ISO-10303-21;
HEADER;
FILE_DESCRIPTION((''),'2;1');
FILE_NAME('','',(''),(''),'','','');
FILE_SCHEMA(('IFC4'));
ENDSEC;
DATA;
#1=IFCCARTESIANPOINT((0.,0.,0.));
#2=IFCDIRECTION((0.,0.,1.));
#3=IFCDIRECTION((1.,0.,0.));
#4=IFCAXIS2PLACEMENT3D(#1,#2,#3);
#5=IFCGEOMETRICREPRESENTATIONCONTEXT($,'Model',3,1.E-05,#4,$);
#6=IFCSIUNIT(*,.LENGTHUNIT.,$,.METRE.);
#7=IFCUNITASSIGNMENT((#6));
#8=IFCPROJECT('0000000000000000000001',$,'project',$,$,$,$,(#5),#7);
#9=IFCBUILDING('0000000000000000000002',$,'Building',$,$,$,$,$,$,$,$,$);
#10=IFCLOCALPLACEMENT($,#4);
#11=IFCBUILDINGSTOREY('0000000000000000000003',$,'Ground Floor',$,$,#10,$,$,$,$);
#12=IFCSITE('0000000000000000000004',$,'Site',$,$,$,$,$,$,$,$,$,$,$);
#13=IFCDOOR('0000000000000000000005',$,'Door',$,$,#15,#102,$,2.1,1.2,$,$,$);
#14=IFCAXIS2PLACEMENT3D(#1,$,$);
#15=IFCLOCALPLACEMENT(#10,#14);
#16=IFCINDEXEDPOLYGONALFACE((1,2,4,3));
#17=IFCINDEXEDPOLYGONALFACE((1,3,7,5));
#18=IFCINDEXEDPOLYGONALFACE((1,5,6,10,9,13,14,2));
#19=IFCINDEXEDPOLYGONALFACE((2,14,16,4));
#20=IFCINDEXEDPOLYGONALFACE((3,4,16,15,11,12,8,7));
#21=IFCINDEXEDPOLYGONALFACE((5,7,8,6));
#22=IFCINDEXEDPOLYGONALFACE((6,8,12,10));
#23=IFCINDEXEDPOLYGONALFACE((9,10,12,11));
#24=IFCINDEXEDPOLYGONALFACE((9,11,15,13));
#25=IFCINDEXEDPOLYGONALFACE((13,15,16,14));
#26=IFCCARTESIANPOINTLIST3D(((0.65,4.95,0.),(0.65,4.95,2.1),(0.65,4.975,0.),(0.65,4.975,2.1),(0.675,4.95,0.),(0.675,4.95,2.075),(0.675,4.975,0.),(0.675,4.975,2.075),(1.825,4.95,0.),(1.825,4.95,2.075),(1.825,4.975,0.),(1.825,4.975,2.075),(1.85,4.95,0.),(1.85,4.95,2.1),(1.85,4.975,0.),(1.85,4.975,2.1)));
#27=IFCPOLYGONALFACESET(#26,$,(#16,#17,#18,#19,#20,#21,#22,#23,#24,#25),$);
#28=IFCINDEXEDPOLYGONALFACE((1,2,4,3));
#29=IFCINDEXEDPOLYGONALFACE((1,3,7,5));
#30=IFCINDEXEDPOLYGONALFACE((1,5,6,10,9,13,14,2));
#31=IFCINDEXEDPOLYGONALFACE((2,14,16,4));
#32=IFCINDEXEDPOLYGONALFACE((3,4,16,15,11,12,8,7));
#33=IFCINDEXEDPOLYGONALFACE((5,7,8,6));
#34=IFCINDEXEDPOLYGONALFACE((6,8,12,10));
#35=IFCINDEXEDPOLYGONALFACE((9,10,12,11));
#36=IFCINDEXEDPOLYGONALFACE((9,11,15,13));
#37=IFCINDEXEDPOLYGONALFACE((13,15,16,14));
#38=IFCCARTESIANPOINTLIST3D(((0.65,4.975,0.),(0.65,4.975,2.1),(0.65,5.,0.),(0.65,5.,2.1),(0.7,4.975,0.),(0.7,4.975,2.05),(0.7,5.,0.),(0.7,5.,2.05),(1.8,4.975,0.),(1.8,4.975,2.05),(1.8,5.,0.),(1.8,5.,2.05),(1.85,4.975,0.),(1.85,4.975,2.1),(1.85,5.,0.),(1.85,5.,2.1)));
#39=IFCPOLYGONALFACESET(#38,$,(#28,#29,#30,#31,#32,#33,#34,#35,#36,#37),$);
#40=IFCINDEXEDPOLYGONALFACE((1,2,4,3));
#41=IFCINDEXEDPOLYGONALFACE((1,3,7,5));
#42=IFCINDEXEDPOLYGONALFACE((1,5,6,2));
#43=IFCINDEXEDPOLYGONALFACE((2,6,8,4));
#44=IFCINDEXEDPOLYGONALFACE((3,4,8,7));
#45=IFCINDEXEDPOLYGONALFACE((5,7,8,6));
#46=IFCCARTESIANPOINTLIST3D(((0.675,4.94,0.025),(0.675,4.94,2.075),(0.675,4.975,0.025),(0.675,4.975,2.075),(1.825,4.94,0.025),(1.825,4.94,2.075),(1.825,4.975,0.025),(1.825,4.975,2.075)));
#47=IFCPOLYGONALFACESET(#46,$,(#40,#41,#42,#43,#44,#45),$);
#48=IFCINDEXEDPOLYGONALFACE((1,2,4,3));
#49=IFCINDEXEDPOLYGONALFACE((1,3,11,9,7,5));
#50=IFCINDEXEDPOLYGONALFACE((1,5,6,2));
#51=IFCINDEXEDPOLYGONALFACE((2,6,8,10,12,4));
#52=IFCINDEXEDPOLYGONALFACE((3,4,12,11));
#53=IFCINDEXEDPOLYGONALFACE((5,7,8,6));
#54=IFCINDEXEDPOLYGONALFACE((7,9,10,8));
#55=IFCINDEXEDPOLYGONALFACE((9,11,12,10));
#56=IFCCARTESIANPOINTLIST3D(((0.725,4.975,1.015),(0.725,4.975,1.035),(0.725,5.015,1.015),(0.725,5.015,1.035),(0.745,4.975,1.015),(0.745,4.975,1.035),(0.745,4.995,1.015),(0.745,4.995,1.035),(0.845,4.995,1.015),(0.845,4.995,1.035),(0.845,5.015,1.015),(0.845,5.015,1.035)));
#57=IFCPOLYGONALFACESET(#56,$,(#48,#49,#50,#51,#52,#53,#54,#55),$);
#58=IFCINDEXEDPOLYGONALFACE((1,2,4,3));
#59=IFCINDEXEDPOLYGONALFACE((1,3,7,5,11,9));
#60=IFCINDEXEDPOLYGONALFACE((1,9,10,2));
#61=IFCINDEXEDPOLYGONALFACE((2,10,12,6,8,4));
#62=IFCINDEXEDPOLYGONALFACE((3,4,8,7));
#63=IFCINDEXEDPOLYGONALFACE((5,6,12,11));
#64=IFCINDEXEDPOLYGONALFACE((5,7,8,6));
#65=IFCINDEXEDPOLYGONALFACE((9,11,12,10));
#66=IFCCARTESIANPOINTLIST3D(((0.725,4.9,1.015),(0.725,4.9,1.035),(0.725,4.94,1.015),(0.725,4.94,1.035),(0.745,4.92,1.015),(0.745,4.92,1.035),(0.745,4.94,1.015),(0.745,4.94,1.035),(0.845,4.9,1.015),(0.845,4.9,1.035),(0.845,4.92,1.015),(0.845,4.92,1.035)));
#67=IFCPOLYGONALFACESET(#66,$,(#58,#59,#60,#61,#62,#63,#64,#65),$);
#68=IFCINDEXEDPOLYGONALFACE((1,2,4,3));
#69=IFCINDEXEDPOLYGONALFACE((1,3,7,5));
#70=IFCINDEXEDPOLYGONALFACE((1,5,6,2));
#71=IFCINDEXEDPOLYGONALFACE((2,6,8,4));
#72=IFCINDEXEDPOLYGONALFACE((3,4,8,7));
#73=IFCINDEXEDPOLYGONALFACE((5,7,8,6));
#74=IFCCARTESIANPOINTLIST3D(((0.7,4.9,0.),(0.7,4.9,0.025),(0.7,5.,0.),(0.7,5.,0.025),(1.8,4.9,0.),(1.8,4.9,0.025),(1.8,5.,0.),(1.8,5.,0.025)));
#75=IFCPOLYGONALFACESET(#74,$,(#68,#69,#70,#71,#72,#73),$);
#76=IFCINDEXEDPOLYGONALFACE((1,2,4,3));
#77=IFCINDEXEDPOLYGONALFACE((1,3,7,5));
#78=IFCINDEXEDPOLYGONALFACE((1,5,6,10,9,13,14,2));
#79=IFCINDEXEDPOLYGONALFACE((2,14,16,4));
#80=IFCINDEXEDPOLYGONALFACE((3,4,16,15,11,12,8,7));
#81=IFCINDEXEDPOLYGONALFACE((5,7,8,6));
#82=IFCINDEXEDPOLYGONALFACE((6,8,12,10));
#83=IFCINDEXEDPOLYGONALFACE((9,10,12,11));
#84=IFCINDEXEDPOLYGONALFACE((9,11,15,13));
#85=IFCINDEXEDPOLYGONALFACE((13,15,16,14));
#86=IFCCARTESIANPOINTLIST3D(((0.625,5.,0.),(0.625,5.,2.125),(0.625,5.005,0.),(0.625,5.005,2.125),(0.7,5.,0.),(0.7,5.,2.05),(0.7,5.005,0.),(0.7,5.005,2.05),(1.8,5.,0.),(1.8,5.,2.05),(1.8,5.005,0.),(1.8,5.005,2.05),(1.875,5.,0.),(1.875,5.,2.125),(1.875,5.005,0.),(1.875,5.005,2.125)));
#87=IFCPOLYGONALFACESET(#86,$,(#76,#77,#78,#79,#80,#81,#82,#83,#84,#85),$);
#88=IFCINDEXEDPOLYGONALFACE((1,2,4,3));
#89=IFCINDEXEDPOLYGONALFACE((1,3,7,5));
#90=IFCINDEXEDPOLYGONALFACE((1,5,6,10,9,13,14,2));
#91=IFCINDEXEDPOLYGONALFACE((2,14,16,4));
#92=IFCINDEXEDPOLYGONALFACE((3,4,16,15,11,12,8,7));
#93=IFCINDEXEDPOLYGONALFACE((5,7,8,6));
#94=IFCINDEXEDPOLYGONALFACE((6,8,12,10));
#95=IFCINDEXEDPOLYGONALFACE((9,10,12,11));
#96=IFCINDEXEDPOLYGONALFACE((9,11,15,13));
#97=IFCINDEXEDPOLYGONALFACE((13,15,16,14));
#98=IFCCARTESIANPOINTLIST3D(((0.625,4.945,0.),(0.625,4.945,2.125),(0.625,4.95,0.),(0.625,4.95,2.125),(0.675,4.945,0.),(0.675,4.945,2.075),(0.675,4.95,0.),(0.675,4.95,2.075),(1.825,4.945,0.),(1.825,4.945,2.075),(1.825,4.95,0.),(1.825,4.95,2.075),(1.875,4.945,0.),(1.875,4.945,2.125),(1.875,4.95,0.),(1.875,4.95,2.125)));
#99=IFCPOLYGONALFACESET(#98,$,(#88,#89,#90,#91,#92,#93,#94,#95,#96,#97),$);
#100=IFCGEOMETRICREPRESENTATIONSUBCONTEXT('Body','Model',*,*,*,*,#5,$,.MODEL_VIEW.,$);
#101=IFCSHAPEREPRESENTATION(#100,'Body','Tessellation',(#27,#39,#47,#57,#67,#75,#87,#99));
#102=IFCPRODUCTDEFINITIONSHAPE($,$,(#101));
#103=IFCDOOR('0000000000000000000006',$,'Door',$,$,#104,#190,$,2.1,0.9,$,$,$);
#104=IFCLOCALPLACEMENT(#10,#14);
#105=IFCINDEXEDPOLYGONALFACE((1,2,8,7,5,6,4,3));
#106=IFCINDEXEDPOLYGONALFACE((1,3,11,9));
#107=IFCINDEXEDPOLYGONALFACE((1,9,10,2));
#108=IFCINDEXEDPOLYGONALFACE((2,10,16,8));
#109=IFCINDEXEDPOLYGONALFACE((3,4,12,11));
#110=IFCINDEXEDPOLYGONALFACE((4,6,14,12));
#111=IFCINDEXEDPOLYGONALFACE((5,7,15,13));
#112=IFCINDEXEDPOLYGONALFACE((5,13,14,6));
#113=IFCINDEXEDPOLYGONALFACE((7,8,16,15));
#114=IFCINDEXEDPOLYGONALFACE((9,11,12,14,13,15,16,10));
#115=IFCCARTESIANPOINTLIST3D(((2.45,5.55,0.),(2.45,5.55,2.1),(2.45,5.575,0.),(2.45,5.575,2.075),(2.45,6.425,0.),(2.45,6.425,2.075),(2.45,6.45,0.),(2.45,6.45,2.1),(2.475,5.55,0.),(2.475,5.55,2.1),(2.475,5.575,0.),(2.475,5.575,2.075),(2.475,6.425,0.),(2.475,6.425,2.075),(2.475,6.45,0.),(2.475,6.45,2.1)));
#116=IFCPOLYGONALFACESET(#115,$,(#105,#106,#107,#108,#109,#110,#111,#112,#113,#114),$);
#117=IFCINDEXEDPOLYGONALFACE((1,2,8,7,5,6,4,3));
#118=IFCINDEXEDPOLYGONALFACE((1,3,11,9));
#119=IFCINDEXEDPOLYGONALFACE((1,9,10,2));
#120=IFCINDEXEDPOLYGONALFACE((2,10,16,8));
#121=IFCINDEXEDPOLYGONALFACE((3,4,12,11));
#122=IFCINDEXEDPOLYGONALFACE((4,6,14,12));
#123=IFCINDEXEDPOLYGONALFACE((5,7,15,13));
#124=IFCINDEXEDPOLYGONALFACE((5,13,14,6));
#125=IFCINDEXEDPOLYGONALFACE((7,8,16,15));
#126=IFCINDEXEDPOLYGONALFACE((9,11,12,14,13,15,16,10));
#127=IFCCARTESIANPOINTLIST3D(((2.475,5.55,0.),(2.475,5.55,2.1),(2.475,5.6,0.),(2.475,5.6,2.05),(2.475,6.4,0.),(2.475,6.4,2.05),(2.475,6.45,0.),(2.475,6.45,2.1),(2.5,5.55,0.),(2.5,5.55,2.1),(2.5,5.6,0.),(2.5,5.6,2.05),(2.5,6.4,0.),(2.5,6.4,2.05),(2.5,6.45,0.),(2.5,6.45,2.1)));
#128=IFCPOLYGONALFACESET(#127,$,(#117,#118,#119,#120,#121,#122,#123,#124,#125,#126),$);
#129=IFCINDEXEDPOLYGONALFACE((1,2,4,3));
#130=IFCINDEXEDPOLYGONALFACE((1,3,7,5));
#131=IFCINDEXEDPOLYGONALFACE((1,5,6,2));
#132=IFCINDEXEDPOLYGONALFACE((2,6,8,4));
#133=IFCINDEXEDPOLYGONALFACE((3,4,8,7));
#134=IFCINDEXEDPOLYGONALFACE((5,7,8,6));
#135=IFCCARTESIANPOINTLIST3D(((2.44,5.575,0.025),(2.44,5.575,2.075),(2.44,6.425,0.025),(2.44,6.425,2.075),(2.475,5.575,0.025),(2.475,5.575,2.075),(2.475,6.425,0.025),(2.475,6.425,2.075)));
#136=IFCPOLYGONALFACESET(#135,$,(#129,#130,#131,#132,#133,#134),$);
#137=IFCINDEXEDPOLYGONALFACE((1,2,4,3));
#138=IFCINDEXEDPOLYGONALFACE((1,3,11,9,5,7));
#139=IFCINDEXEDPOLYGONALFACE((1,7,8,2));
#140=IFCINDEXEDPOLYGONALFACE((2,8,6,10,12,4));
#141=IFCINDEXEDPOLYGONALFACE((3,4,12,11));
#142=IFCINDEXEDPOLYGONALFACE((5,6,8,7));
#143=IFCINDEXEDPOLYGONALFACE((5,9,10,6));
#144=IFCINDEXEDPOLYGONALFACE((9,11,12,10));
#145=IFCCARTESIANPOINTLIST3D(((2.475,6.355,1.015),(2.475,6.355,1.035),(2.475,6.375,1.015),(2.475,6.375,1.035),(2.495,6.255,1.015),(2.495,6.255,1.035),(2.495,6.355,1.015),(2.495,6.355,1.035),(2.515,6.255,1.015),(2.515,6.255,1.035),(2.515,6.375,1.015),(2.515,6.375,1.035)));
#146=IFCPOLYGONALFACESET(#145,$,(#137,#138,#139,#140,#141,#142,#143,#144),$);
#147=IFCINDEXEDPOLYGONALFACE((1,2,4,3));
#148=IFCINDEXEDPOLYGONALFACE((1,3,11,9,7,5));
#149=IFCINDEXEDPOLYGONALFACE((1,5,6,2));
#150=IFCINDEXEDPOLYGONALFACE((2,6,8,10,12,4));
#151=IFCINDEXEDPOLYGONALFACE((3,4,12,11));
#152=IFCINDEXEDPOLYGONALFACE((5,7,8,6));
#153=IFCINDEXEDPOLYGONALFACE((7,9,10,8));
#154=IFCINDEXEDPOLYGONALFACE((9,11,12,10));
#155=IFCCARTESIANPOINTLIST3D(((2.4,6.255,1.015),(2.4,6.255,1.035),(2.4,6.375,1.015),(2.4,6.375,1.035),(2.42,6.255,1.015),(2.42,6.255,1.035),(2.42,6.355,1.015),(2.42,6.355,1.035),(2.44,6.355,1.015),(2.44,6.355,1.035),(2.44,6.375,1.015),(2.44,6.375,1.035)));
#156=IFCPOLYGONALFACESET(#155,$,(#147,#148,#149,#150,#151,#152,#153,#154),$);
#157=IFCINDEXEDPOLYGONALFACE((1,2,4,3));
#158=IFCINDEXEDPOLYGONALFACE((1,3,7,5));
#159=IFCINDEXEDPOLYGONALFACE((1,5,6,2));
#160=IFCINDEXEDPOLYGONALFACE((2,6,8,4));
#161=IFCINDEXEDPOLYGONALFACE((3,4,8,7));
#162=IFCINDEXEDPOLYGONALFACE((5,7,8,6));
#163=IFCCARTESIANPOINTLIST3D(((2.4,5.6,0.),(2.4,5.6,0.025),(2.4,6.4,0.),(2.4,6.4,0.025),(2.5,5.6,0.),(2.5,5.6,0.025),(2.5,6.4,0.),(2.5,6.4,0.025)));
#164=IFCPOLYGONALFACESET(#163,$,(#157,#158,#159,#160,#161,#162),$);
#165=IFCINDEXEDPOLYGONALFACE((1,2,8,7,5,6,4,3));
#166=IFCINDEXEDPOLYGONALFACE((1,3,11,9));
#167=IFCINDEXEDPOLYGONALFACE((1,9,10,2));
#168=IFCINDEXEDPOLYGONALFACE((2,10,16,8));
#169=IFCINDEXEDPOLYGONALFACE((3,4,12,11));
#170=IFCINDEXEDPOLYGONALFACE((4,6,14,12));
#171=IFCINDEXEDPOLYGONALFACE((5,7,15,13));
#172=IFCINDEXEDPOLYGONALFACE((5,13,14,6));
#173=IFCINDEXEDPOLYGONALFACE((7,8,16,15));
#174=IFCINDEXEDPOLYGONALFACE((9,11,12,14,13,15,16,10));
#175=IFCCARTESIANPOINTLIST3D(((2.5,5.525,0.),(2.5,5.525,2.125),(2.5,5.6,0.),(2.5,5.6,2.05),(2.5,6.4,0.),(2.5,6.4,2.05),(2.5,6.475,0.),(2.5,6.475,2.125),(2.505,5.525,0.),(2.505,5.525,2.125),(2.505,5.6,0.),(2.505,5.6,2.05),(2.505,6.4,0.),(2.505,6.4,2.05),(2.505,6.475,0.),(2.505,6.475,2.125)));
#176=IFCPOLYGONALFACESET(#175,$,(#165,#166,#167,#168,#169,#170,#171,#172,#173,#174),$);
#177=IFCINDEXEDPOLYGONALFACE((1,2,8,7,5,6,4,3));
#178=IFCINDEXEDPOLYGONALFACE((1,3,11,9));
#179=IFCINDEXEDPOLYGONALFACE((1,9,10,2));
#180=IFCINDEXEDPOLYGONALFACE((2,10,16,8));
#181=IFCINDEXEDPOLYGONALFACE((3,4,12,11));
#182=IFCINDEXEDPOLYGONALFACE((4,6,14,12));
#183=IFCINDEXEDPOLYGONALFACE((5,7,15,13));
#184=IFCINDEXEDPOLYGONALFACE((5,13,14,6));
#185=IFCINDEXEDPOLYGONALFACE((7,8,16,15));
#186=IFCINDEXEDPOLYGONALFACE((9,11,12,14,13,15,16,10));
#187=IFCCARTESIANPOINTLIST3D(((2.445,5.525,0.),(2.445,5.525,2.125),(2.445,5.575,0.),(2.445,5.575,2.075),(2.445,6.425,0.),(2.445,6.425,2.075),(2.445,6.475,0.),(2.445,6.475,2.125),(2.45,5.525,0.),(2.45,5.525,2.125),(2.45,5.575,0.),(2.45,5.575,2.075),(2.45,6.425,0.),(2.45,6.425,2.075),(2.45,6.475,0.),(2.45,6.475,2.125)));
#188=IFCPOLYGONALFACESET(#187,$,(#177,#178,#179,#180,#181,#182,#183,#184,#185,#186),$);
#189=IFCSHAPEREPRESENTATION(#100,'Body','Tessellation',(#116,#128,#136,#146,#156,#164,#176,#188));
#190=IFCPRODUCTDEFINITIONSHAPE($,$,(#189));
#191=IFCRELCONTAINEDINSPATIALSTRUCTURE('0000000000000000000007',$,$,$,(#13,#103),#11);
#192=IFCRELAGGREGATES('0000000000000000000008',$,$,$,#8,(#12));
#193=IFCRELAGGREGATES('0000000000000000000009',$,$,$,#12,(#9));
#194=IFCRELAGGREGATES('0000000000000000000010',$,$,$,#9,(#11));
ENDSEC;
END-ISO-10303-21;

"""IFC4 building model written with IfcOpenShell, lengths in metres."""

from ifc_helpers import new_model, si_unit, frame, origin_with_axes, place, context, subcontext, project, spatial, line, indexed_curve, outline, extrude, element, save


model = new_model("IFC4")

# Units and contexts
model_context = context("Model", 3, precision=1e-05, world=origin_with_axes())
body_context = subcontext(model_context, "Body", "Model", "MODEL_VIEW")
ifc_project = project(units=[si_unit("LENGTHUNIT", "METRE")], contexts=[model_context])

# Site, building, storey
site = spatial("IfcSite", under=ifc_project, Name="Site")
building = spatial("IfcBuilding", under=site, Name="Building")
storey_placement = place(None, origin_with_axes())
storey = spatial("IfcBuildingStorey", under=building, at=storey_placement, Name="Ground Floor")

# Doors
door_1_placement = place(storey_placement, frame((1.85, 5.0, 0.0), z_axis=(0.0, 0.0, 1.0), x_axis=(-1.0, 0.0, 0.0)))
element("IfcDoor", 1, at=door_1_placement, inside=storey, Name="Door", OverallHeight=2.1, OverallWidth=1.2, context=body_context, shape_type="SweptSolid", body=[
    extrude(outline(indexed_curve([(0.0, 0.0), (0.0, 2.1), (1.2, 2.1), (1.2, 0.0), (1.175, 0.0), (1.175, 2.075), (0.025, 2.075), (0.025, 0.0)], segments=[line(1, 2, 3, 4, 5, 6, 7, 8, 1)])), frame((0.0, 0.025, 0.0), z_axis=(0.0, -1.0, 0.0), x_axis=(1.0, 0.0, 0.0)), (0.0, 0.0, -1.0), 0.025),
    extrude(outline(indexed_curve([(0.0, 0.0), (0.0, 2.1), (1.2, 2.1), (1.2, 0.0), (1.15, 0.0), (1.15, 2.05), (0.05, 2.05), (0.05, 0.0)], segments=[line(1, 2, 3, 4, 5, 6, 7, 8, 1)])), frame((0.0, 0.0, 0.0), z_axis=(0.0, -1.0, 0.0), x_axis=(1.0, 0.0, 0.0)), (0.0, 0.0, -1.0), 0.025),
    extrude(outline(indexed_curve([(0.0, 0.0), (1.15, 0.0), (1.15, 0.035), (0.0, 0.035)], segments=[line(1, 2, 3, 4, 1)])), frame((0.025, 0.025, 0.025), z_axis=(0.0, 0.0, 1.0), x_axis=(1.0, 0.0, 0.0)), (0.0, 0.0, 1.0), 2.05),
    extrude(outline(indexed_curve([(0.0, 0.0), (0.0, -0.04), (-0.12, -0.04), (-0.12, -0.02), (-0.02, -0.02), (-0.02, 0.0)], segments=[line(1, 2, 3, 4, 5, 6, 1)])), frame((1.125, 0.025, 1.015), z_axis=(0.0, 0.0, 1.0), x_axis=(1.0, 0.0, 0.0)), (0.0, 0.0, 1.0), 0.02),
    extrude(outline(indexed_curve([(0.0, 0.0), (0.0, 0.04), (-0.12, 0.04), (-0.12, 0.02), (-0.02, 0.02), (-0.02, 0.0)], segments=[line(1, 2, 3, 4, 5, 6, 1)])), frame((1.125, 0.06, 1.015), z_axis=(0.0, 0.0, 1.0), x_axis=(1.0, 0.0, 0.0)), (0.0, 0.0, 1.0), 0.02),
    extrude(outline(indexed_curve([(0.0, 0.0), (1.1, 0.0), (1.1, 0.1), (0.0, 0.1)], segments=[line(1, 2, 3, 4, 1)])), frame((0.05, 0.0, 0.0), z_axis=(0.0, 0.0, 1.0), x_axis=(1.0, 0.0, 0.0)), (0.0, 0.0, 1.0), 0.025),
    extrude(outline(indexed_curve([(0.0, 0.0), (0.0, 2.125), (1.25, 2.125), (1.25, 0.0), (1.175, 0.0), (1.175, 2.05), (0.075, 2.05), (0.075, 0.0)], segments=[line(1, 2, 3, 4, 5, 6, 7, 8, 1)])), frame((-0.025, -0.005, 0.0), z_axis=(0.0, -1.0, 0.0), x_axis=(1.0, 0.0, 0.0)), (0.0, 0.0, -1.0), 0.005),
    extrude(outline(indexed_curve([(0.0, 0.0), (0.0, 2.125), (1.25, 2.125), (1.25, 0.0), (1.2, 0.0), (1.2, 2.075), (0.05, 2.075), (0.05, 0.0)], segments=[line(1, 2, 3, 4, 5, 6, 7, 8, 1)])), frame((-0.025, 0.05, 0.0), z_axis=(0.0, -1.0, 0.0), x_axis=(1.0, 0.0, 0.0)), (0.0, 0.0, -1.0), 0.005),
])
door_2_placement = place(storey_placement, frame((2.5, 5.55, 0.0), z_axis=(0.0, 0.0, 1.0), x_axis=(0.0, 1.0, 0.0)))
element("IfcDoor", 2, at=door_2_placement, inside=storey, Name="Door", OverallHeight=2.1, OverallWidth=0.9, context=body_context, shape_type="SweptSolid", body=[
    extrude(outline(indexed_curve([(0.0, 0.0), (0.0, 2.1), (0.9, 2.1), (0.9, 0.0), (0.875, 0.0), (0.875, 2.075), (0.025, 2.075), (0.025, 0.0)], segments=[line(1, 2, 3, 4, 5, 6, 7, 8, 1)])), frame((0.0, 0.025, 0.0), z_axis=(0.0, -1.0, 0.0), x_axis=(1.0, 0.0, 0.0)), (0.0, 0.0, -1.0), 0.025),
    extrude(outline(indexed_curve([(0.0, 0.0), (0.0, 2.1), (0.9, 2.1), (0.9, 0.0), (0.85, 0.0), (0.85, 2.05), (0.05, 2.05), (0.05, 0.0)], segments=[line(1, 2, 3, 4, 5, 6, 7, 8, 1)])), frame((0.0, 0.0, 0.0), z_axis=(0.0, -1.0, 0.0), x_axis=(1.0, 0.0, 0.0)), (0.0, 0.0, -1.0), 0.025),
    extrude(outline(indexed_curve([(0.0, 0.0), (0.85, 0.0), (0.85, 0.035), (0.0, 0.035)], segments=[line(1, 2, 3, 4, 1)])), frame((0.025, 0.025, 0.025), z_axis=(0.0, 0.0, 1.0), x_axis=(1.0, 0.0, 0.0)), (0.0, 0.0, 1.0), 2.05),
    extrude(outline(indexed_curve([(0.0, 0.0), (0.0, -0.04), (-0.12, -0.04), (-0.12, -0.02), (-0.02, -0.02), (-0.02, 0.0)], segments=[line(1, 2, 3, 4, 5, 6, 1)])), frame((0.825, 0.025, 1.015), z_axis=(0.0, 0.0, 1.0), x_axis=(1.0, 0.0, 0.0)), (0.0, 0.0, 1.0), 0.02),
    extrude(outline(indexed_curve([(0.0, 0.0), (0.0, 0.04), (-0.12, 0.04), (-0.12, 0.02), (-0.02, 0.02), (-0.02, 0.0)], segments=[line(1, 2, 3, 4, 5, 6, 1)])), frame((0.825, 0.06, 1.015), z_axis=(0.0, 0.0, 1.0), x_axis=(1.0, 0.0, 0.0)), (0.0, 0.0, 1.0), 0.02),
    extrude(outline(indexed_curve([(0.0, 0.0), (0.8, 0.0), (0.8, 0.1), (0.0, 0.1)], segments=[line(1, 2, 3, 4, 1)])), frame((0.05, 0.0, 0.0), z_axis=(0.0, 0.0, 1.0), x_axis=(1.0, 0.0, 0.0)), (0.0, 0.0, 1.0), 0.025),
    extrude(outline(indexed_curve([(0.0, 0.0), (0.0, 2.125), (0.95, 2.125), (0.95, 0.0), (0.875, 0.0), (0.875, 2.05), (0.075, 2.05), (0.075, 0.0)], segments=[line(1, 2, 3, 4, 5, 6, 7, 8, 1)])), frame((-0.025, -0.005, 0.0), z_axis=(0.0, -1.0, 0.0), x_axis=(1.0, 0.0, 0.0)), (0.0, 0.0, -1.0), 0.005),
    extrude(outline(indexed_curve([(0.0, 0.0), (0.0, 2.125), (0.95, 2.125), (0.95, 0.0), (0.9, 0.0), (0.9, 2.075), (0.05, 2.075), (0.05, 0.0)], segments=[line(1, 2, 3, 4, 5, 6, 7, 8, 1)])), frame((-0.025, 0.05, 0.0), z_axis=(0.0, -1.0, 0.0), x_axis=(1.0, 0.0, 0.0)), (0.0, 0.0, -1.0), 0.005),
])

save(model, "model.ifc")
